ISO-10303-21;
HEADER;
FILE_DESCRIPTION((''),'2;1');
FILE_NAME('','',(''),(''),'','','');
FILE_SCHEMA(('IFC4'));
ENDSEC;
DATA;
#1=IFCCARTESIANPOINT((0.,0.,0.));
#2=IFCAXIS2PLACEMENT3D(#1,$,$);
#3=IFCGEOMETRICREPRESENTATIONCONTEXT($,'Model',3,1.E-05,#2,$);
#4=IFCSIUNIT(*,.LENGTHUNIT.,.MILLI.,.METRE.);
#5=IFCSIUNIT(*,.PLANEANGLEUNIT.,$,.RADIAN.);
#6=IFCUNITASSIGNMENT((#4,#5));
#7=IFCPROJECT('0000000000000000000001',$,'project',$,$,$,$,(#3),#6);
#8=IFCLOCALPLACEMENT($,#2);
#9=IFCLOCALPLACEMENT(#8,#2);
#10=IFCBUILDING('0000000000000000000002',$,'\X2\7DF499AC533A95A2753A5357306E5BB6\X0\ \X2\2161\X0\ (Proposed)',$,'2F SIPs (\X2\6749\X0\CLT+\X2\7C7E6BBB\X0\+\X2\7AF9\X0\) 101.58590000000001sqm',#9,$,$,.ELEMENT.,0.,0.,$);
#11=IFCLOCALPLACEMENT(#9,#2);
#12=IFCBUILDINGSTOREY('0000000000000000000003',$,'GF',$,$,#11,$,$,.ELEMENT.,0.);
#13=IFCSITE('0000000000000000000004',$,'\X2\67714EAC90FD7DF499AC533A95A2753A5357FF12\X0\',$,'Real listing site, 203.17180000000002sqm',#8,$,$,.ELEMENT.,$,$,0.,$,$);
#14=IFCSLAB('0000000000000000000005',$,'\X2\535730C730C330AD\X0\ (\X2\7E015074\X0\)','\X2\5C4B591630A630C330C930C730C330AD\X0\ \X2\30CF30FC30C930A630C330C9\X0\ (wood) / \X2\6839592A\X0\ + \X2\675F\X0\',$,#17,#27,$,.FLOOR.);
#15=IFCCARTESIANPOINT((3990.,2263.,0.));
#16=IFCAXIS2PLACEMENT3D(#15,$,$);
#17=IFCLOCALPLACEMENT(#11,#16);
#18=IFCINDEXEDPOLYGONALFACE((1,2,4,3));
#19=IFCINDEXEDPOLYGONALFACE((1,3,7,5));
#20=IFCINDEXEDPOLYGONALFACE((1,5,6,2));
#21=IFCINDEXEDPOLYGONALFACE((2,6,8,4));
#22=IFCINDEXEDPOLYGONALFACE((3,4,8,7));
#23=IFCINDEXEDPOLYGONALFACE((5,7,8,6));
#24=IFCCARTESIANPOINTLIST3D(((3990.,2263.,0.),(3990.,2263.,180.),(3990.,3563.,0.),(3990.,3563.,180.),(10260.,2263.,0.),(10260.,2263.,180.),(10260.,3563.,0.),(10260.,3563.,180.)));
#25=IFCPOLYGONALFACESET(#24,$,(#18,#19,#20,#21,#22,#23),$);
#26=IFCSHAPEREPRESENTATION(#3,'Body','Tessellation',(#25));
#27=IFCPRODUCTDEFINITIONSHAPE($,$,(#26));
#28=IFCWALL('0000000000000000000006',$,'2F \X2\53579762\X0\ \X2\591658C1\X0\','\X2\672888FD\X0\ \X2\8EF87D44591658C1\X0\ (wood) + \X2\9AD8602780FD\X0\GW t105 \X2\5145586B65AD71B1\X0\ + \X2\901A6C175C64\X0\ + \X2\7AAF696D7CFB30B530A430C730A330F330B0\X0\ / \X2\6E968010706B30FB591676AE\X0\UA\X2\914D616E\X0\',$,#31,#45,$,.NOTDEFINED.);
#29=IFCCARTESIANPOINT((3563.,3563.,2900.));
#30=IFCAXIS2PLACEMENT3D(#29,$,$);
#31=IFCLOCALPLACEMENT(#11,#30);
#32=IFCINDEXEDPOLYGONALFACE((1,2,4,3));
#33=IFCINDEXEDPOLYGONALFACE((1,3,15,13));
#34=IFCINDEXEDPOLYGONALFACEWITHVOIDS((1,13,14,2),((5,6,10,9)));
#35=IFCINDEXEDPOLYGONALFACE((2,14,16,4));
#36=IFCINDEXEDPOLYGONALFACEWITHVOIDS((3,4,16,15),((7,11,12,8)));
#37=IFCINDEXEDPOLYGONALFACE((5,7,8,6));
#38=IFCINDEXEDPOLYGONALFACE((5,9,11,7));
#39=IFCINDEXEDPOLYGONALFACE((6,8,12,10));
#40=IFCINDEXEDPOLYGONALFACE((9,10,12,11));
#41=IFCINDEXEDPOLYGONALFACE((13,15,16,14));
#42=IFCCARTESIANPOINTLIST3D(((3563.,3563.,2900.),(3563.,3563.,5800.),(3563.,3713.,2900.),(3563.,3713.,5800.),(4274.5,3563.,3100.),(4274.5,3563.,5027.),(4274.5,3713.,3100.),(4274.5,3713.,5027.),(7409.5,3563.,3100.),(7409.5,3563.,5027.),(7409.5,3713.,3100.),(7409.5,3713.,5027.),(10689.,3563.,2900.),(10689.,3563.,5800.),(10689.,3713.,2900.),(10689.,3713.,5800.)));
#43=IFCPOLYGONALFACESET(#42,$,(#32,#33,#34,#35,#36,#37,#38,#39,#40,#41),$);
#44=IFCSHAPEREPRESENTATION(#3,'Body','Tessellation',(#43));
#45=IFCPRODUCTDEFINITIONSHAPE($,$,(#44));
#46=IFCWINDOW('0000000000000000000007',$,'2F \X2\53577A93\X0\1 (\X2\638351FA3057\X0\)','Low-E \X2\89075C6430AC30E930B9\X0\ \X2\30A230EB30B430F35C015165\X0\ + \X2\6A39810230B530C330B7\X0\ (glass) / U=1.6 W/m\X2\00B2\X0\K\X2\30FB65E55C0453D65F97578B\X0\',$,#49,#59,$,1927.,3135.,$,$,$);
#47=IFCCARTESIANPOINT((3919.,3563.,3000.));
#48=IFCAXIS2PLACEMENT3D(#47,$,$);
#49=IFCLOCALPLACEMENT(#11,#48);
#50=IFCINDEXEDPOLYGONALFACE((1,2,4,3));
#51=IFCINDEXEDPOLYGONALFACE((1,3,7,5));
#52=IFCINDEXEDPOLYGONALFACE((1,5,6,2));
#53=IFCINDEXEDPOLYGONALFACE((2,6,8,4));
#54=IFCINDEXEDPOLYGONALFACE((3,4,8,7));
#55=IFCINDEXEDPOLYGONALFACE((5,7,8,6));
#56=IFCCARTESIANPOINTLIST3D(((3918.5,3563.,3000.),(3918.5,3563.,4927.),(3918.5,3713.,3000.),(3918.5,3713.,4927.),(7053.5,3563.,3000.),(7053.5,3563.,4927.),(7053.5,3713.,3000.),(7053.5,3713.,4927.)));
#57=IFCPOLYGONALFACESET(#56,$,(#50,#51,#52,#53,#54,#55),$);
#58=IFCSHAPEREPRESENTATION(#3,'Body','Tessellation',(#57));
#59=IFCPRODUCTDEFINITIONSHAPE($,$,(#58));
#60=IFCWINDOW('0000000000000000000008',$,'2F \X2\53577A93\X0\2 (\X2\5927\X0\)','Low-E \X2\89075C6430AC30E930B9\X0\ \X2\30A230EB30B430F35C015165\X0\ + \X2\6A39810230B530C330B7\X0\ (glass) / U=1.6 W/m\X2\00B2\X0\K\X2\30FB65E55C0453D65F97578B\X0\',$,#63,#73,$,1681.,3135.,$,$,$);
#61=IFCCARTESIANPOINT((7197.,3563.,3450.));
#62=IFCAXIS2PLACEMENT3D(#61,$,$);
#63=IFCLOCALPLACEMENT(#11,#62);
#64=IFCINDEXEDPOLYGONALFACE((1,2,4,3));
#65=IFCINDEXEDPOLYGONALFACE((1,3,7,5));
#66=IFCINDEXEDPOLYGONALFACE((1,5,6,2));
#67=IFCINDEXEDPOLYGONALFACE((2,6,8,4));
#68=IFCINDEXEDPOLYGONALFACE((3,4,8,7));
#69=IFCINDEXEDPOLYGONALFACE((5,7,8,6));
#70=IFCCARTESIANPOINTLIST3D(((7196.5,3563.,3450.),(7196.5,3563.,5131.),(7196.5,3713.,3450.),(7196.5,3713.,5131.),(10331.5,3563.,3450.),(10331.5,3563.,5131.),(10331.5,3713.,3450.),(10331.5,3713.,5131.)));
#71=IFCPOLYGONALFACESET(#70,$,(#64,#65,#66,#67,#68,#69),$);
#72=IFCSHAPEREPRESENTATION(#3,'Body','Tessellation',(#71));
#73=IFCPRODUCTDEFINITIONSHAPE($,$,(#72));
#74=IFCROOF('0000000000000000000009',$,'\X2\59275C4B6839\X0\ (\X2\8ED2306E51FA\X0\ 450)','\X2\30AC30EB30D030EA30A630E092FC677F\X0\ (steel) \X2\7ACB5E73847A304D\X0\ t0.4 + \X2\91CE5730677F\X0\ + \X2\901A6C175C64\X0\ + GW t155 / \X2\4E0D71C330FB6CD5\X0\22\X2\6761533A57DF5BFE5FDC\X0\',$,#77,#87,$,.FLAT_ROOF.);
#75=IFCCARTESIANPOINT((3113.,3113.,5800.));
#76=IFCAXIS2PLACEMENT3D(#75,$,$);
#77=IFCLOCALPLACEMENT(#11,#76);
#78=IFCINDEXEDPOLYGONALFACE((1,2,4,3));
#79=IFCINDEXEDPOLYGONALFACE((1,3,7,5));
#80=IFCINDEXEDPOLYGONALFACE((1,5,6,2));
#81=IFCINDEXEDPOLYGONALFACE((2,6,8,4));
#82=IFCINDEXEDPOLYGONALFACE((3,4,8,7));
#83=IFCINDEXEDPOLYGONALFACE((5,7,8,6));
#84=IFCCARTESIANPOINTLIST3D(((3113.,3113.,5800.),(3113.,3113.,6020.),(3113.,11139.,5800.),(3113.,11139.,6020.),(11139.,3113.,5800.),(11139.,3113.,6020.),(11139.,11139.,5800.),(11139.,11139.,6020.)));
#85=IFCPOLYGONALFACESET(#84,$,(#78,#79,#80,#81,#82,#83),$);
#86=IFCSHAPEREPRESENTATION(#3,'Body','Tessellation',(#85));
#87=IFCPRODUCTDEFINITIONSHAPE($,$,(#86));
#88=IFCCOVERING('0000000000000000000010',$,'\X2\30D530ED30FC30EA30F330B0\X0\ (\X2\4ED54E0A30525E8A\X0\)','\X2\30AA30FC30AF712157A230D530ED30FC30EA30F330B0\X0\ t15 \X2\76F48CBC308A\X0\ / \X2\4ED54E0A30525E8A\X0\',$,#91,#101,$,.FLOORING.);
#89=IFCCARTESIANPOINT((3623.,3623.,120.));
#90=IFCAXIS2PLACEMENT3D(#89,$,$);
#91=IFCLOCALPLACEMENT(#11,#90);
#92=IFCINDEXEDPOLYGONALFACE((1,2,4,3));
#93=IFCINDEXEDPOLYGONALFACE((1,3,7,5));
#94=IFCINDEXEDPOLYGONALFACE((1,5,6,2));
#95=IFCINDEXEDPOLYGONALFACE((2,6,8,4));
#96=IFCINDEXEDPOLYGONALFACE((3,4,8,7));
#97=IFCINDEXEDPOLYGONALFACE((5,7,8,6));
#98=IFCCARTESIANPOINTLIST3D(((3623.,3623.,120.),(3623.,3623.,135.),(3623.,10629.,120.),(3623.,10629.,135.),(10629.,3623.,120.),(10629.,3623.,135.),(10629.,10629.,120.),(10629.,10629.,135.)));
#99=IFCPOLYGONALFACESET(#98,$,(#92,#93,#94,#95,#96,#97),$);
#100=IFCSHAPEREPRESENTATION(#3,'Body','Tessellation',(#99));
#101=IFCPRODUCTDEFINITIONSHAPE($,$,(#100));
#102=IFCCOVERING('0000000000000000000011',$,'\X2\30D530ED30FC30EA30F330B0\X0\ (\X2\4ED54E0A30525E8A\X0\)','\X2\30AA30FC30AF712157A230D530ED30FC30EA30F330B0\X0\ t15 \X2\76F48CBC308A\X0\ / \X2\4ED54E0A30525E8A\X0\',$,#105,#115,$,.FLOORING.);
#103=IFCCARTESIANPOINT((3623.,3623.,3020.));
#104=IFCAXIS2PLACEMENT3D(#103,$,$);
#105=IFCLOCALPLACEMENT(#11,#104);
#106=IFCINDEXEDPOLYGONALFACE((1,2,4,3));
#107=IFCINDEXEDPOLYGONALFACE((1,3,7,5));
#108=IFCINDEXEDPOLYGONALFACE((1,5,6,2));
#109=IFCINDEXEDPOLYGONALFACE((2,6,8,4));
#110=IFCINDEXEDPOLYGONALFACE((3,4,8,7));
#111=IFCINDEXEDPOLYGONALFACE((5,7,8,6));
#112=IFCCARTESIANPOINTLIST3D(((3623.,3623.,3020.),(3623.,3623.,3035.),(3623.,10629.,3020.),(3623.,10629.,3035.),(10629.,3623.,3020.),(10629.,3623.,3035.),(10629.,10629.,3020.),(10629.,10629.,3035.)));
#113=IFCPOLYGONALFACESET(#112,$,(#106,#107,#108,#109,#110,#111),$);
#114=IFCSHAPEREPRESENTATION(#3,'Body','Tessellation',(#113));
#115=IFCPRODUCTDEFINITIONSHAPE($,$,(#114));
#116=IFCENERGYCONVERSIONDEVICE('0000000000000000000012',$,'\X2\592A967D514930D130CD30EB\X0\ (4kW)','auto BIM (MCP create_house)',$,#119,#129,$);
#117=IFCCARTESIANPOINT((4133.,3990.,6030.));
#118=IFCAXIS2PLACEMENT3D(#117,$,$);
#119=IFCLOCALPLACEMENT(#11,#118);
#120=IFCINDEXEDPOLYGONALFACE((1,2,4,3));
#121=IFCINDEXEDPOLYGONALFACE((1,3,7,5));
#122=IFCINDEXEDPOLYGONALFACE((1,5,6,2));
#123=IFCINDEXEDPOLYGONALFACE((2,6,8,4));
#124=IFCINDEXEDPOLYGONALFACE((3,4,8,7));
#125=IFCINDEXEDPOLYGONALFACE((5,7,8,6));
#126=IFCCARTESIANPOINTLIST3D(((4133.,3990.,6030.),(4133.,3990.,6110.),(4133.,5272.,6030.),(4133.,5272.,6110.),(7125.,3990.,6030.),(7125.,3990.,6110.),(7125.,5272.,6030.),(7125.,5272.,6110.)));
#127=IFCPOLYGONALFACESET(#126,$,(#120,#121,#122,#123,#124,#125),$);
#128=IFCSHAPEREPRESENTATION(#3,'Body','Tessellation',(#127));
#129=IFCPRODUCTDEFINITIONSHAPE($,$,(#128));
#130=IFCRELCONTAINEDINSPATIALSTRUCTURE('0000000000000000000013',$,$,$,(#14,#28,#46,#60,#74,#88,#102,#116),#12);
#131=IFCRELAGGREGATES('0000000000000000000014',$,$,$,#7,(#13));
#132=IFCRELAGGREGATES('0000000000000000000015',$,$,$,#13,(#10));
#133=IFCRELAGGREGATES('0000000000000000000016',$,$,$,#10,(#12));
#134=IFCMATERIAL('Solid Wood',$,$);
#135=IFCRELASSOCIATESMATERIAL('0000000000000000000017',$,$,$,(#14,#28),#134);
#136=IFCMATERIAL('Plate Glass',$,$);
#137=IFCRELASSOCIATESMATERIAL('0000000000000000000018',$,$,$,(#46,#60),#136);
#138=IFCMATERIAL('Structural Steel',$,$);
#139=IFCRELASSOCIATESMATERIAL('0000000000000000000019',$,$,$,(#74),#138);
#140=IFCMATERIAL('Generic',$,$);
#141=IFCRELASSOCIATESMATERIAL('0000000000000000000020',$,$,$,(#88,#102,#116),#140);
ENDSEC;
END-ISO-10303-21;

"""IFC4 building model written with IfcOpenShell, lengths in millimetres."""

from ifc_helpers import new_model, si_unit, frame, frame_2d, origin, place, context, project, spatial, rectangle, extrude, material, element, fill, save


model = new_model("IFC4")

# Units and contexts
model_context = context("Model", 3, precision=1e-05, world=origin())
ifc_project = project(units=[si_unit("LENGTHUNIT", "METRE", prefix="MILLI"), si_unit("PLANEANGLEUNIT", "RADIAN")], contexts=[model_context])

# Site, building, storey
site_placement = place(None, origin())
site = spatial("IfcSite", under=ifc_project, at=site_placement, Name="東京都練馬区関町南２", ObjectType="Real listing site, 203.17180000000002sqm", CompositionType="ELEMENT", RefElevation=0.0)
building_placement = place(site_placement, origin())
building = spatial("IfcBuilding", under=site, at=building_placement, Name="練馬区関町南の家 Ⅱ (Proposed)", ObjectType="2F SIPs (杉CLT+籾殻+竹) 101.58590000000001sqm", CompositionType="ELEMENT", ElevationOfRefHeight=0.0, ElevationOfTerrain=0.0)
storey_placement = place(building_placement, origin())
storey = spatial("IfcBuildingStorey", under=building, at=storey_placement, Name="GF", CompositionType="ELEMENT", Elevation=0.0)

# Slab
ifc_material_1 = material(Name="Solid Wood")
slab_1_placement = place(storey_placement, frame((3990.0, 2263.0, 0.0)))
element("IfcSlab", 1, at=slab_1_placement, inside=storey, material=ifc_material_1, Name="南デッキ (縁側)", Description="屋外ウッドデッキ ハードウッド (wood) / 根太 + 束", PredefinedType="FLOOR", context=model_context, shape_type="SweptSolid", body=[
    extrude(rectangle(XDim=6270.0, YDim=1300.0, at=frame_2d((3135.0, 650.0))), frame((3990.0, 2263.0, 0.0)), (0.0, 0.0, 1.0), 180.0),
])

# Shared definitions
ifc_material_2 = material(Name="Plate Glass")

# Wall, openings, windows
wall_1_placement = place(storey_placement, frame((3563.0, 3563.0, 2900.0)))
wall_1 = element("IfcWall", 2, at=wall_1_placement, inside=storey, material=ifc_material_1, Name="2F 南面 外壁", Description="木製 軸組外壁 (wood) + 高性能GW t105 充填断熱 + 通気層 + 窯業系サイディング / 準耐火・外皮UA配慮", PredefinedType="NOTDEFINED", context=model_context, shape_type="SweptSolid", body=[
    extrude(rectangle(XDim=7126.0, YDim=150.0, at=frame_2d((3563.0, 75.0))), frame((3563.0, 3563.0, 2900.0)), (0.0, 0.0, 1.0), 2900.0),
])
opening_1_placement = place(storey_placement, frame((3919.0, 3563.0, 3000.0)))
opening_1 = element("IfcOpeningElement", 3, at=opening_1_placement, cuts=wall_1, PredefinedType="NOTDEFINED", context=model_context, shape_type="SweptSolid", body=[
    extrude(rectangle(XDim=3135.0, YDim=150.0, at=frame_2d((1567.0, 75.0))), frame((3919.0, 3563.0, 3000.0)), (0.0, 0.0, 1.0), 1927.0),
])
opening_2_placement = place(storey_placement, frame((7197.0, 3563.0, 3450.0)))
opening_2 = element("IfcOpeningElement", 4, at=opening_2_placement, cuts=wall_1, PredefinedType="NOTDEFINED", context=model_context, shape_type="SweptSolid", body=[
    extrude(rectangle(XDim=3135.0, YDim=150.0, at=frame_2d((1567.0, 75.0))), frame((7197.0, 3563.0, 3450.0)), (0.0, 0.0, 1.0), 1681.0),
])
window_1_placement = place(storey_placement, frame((3919.0, 3563.0, 3000.0)))
window_1 = element("IfcWindow", 5, at=window_1_placement, inside=storey, material=ifc_material_2, Name="2F 南窓1 (掃出し)", Description="Low-E 複層ガラス アルゴン封入 + 樹脂サッシ (glass) / U=1.6 W/m²K・日射取得型", OverallHeight=1927.0, OverallWidth=3135.0, context=model_context, shape_type="SweptSolid", body=[
    extrude(rectangle(XDim=3135.0, YDim=150.0, at=frame_2d((1567.0, 75.0))), frame((3919.0, 3563.0, 3000.0)), (0.0, 0.0, 1.0), 1927.0),
])
fill(opening_1, window_1)
window_2_placement = place(storey_placement, frame((7197.0, 3563.0, 3450.0)))
window_2 = element("IfcWindow", 6, at=window_2_placement, inside=storey, material=ifc_material_2, Name="2F 南窓2 (大)", Description="Low-E 複層ガラス アルゴン封入 + 樹脂サッシ (glass) / U=1.6 W/m²K・日射取得型", OverallHeight=1681.0, OverallWidth=3135.0, context=model_context, shape_type="SweptSolid", body=[
    extrude(rectangle(XDim=3135.0, YDim=150.0, at=frame_2d((1567.0, 75.0))), frame((7197.0, 3563.0, 3450.0)), (0.0, 0.0, 1.0), 1681.0),
])
fill(opening_2, window_2)

# Roof
ifc_material_3 = material(Name="Structural Steel")
roof_placement = place(storey_placement, frame((3113.0, 3113.0, 5800.0)))
element("IfcRoof", 7, at=roof_placement, inside=storey, material=ifc_material_3, Name="大屋根 (軒の出 450)", Description="ガルバリウム鋼板 (steel) 立平葺き t0.4 + 野地板 + 通気層 + GW t155 / 不燃・法22条区域対応", PredefinedType="FLAT_ROOF", context=model_context, shape_type="SweptSolid", body=[
    extrude(rectangle(XDim=8026.0, YDim=8026.0, at=frame_2d((4013.0, 4013.0))), frame((3113.0, 3113.0, 5800.0)), (0.0, 0.0, 1.0), 220.0),
])

# Coverings
ifc_material_4 = material(Name="Generic")
covering_1_placement = place(storey_placement, frame((3623.0, 3623.0, 120.0)))
element("IfcCovering", 8, at=covering_1_placement, inside=storey, material=ifc_material_4, Name="フローリング (仕上げ床)", Description="オーク無垢フローリング t15 直貼り / 仕上げ床", PredefinedType="FLOORING", context=model_context, shape_type="SweptSolid", body=[
    extrude(rectangle(XDim=7006.0, YDim=7006.0, at=frame_2d((3503.0, 3503.0))), frame((3623.0, 3623.0, 120.0)), (0.0, 0.0, 1.0), 15.0),
])
covering_2_placement = place(storey_placement, frame((3623.0, 3623.0, 3020.0)))
element("IfcCovering", 9, at=covering_2_placement, inside=storey, material=ifc_material_4, Name="フローリング (仕上げ床)", Description="オーク無垢フローリング t15 直貼り / 仕上げ床", PredefinedType="FLOORING", context=model_context, shape_type="SweptSolid", body=[
    extrude(rectangle(XDim=7006.0, YDim=7006.0, at=frame_2d((3503.0, 3503.0))), frame((3623.0, 3623.0, 3020.0)), (0.0, 0.0, 1.0), 15.0),
])

# Energy conversion device
energy_conversion_device_placement = place(storey_placement, frame((4133.0, 3990.0, 6030.0)))
element("IfcEnergyConversionDevice", 10, at=energy_conversion_device_placement, inside=storey, material=ifc_material_4, Name="太陽光パネル (4kW)", Description="auto BIM (MCP create_house)", context=model_context, shape_type="SweptSolid", body=[
    extrude(rectangle(XDim=2992.0, YDim=1282.0, at=frame_2d((1496.0, 641.0))), frame((4133.0, 3990.0, 6030.0)), (0.0, 0.0, 1.0), 80.0),
])

save(model, "model.ifc")
